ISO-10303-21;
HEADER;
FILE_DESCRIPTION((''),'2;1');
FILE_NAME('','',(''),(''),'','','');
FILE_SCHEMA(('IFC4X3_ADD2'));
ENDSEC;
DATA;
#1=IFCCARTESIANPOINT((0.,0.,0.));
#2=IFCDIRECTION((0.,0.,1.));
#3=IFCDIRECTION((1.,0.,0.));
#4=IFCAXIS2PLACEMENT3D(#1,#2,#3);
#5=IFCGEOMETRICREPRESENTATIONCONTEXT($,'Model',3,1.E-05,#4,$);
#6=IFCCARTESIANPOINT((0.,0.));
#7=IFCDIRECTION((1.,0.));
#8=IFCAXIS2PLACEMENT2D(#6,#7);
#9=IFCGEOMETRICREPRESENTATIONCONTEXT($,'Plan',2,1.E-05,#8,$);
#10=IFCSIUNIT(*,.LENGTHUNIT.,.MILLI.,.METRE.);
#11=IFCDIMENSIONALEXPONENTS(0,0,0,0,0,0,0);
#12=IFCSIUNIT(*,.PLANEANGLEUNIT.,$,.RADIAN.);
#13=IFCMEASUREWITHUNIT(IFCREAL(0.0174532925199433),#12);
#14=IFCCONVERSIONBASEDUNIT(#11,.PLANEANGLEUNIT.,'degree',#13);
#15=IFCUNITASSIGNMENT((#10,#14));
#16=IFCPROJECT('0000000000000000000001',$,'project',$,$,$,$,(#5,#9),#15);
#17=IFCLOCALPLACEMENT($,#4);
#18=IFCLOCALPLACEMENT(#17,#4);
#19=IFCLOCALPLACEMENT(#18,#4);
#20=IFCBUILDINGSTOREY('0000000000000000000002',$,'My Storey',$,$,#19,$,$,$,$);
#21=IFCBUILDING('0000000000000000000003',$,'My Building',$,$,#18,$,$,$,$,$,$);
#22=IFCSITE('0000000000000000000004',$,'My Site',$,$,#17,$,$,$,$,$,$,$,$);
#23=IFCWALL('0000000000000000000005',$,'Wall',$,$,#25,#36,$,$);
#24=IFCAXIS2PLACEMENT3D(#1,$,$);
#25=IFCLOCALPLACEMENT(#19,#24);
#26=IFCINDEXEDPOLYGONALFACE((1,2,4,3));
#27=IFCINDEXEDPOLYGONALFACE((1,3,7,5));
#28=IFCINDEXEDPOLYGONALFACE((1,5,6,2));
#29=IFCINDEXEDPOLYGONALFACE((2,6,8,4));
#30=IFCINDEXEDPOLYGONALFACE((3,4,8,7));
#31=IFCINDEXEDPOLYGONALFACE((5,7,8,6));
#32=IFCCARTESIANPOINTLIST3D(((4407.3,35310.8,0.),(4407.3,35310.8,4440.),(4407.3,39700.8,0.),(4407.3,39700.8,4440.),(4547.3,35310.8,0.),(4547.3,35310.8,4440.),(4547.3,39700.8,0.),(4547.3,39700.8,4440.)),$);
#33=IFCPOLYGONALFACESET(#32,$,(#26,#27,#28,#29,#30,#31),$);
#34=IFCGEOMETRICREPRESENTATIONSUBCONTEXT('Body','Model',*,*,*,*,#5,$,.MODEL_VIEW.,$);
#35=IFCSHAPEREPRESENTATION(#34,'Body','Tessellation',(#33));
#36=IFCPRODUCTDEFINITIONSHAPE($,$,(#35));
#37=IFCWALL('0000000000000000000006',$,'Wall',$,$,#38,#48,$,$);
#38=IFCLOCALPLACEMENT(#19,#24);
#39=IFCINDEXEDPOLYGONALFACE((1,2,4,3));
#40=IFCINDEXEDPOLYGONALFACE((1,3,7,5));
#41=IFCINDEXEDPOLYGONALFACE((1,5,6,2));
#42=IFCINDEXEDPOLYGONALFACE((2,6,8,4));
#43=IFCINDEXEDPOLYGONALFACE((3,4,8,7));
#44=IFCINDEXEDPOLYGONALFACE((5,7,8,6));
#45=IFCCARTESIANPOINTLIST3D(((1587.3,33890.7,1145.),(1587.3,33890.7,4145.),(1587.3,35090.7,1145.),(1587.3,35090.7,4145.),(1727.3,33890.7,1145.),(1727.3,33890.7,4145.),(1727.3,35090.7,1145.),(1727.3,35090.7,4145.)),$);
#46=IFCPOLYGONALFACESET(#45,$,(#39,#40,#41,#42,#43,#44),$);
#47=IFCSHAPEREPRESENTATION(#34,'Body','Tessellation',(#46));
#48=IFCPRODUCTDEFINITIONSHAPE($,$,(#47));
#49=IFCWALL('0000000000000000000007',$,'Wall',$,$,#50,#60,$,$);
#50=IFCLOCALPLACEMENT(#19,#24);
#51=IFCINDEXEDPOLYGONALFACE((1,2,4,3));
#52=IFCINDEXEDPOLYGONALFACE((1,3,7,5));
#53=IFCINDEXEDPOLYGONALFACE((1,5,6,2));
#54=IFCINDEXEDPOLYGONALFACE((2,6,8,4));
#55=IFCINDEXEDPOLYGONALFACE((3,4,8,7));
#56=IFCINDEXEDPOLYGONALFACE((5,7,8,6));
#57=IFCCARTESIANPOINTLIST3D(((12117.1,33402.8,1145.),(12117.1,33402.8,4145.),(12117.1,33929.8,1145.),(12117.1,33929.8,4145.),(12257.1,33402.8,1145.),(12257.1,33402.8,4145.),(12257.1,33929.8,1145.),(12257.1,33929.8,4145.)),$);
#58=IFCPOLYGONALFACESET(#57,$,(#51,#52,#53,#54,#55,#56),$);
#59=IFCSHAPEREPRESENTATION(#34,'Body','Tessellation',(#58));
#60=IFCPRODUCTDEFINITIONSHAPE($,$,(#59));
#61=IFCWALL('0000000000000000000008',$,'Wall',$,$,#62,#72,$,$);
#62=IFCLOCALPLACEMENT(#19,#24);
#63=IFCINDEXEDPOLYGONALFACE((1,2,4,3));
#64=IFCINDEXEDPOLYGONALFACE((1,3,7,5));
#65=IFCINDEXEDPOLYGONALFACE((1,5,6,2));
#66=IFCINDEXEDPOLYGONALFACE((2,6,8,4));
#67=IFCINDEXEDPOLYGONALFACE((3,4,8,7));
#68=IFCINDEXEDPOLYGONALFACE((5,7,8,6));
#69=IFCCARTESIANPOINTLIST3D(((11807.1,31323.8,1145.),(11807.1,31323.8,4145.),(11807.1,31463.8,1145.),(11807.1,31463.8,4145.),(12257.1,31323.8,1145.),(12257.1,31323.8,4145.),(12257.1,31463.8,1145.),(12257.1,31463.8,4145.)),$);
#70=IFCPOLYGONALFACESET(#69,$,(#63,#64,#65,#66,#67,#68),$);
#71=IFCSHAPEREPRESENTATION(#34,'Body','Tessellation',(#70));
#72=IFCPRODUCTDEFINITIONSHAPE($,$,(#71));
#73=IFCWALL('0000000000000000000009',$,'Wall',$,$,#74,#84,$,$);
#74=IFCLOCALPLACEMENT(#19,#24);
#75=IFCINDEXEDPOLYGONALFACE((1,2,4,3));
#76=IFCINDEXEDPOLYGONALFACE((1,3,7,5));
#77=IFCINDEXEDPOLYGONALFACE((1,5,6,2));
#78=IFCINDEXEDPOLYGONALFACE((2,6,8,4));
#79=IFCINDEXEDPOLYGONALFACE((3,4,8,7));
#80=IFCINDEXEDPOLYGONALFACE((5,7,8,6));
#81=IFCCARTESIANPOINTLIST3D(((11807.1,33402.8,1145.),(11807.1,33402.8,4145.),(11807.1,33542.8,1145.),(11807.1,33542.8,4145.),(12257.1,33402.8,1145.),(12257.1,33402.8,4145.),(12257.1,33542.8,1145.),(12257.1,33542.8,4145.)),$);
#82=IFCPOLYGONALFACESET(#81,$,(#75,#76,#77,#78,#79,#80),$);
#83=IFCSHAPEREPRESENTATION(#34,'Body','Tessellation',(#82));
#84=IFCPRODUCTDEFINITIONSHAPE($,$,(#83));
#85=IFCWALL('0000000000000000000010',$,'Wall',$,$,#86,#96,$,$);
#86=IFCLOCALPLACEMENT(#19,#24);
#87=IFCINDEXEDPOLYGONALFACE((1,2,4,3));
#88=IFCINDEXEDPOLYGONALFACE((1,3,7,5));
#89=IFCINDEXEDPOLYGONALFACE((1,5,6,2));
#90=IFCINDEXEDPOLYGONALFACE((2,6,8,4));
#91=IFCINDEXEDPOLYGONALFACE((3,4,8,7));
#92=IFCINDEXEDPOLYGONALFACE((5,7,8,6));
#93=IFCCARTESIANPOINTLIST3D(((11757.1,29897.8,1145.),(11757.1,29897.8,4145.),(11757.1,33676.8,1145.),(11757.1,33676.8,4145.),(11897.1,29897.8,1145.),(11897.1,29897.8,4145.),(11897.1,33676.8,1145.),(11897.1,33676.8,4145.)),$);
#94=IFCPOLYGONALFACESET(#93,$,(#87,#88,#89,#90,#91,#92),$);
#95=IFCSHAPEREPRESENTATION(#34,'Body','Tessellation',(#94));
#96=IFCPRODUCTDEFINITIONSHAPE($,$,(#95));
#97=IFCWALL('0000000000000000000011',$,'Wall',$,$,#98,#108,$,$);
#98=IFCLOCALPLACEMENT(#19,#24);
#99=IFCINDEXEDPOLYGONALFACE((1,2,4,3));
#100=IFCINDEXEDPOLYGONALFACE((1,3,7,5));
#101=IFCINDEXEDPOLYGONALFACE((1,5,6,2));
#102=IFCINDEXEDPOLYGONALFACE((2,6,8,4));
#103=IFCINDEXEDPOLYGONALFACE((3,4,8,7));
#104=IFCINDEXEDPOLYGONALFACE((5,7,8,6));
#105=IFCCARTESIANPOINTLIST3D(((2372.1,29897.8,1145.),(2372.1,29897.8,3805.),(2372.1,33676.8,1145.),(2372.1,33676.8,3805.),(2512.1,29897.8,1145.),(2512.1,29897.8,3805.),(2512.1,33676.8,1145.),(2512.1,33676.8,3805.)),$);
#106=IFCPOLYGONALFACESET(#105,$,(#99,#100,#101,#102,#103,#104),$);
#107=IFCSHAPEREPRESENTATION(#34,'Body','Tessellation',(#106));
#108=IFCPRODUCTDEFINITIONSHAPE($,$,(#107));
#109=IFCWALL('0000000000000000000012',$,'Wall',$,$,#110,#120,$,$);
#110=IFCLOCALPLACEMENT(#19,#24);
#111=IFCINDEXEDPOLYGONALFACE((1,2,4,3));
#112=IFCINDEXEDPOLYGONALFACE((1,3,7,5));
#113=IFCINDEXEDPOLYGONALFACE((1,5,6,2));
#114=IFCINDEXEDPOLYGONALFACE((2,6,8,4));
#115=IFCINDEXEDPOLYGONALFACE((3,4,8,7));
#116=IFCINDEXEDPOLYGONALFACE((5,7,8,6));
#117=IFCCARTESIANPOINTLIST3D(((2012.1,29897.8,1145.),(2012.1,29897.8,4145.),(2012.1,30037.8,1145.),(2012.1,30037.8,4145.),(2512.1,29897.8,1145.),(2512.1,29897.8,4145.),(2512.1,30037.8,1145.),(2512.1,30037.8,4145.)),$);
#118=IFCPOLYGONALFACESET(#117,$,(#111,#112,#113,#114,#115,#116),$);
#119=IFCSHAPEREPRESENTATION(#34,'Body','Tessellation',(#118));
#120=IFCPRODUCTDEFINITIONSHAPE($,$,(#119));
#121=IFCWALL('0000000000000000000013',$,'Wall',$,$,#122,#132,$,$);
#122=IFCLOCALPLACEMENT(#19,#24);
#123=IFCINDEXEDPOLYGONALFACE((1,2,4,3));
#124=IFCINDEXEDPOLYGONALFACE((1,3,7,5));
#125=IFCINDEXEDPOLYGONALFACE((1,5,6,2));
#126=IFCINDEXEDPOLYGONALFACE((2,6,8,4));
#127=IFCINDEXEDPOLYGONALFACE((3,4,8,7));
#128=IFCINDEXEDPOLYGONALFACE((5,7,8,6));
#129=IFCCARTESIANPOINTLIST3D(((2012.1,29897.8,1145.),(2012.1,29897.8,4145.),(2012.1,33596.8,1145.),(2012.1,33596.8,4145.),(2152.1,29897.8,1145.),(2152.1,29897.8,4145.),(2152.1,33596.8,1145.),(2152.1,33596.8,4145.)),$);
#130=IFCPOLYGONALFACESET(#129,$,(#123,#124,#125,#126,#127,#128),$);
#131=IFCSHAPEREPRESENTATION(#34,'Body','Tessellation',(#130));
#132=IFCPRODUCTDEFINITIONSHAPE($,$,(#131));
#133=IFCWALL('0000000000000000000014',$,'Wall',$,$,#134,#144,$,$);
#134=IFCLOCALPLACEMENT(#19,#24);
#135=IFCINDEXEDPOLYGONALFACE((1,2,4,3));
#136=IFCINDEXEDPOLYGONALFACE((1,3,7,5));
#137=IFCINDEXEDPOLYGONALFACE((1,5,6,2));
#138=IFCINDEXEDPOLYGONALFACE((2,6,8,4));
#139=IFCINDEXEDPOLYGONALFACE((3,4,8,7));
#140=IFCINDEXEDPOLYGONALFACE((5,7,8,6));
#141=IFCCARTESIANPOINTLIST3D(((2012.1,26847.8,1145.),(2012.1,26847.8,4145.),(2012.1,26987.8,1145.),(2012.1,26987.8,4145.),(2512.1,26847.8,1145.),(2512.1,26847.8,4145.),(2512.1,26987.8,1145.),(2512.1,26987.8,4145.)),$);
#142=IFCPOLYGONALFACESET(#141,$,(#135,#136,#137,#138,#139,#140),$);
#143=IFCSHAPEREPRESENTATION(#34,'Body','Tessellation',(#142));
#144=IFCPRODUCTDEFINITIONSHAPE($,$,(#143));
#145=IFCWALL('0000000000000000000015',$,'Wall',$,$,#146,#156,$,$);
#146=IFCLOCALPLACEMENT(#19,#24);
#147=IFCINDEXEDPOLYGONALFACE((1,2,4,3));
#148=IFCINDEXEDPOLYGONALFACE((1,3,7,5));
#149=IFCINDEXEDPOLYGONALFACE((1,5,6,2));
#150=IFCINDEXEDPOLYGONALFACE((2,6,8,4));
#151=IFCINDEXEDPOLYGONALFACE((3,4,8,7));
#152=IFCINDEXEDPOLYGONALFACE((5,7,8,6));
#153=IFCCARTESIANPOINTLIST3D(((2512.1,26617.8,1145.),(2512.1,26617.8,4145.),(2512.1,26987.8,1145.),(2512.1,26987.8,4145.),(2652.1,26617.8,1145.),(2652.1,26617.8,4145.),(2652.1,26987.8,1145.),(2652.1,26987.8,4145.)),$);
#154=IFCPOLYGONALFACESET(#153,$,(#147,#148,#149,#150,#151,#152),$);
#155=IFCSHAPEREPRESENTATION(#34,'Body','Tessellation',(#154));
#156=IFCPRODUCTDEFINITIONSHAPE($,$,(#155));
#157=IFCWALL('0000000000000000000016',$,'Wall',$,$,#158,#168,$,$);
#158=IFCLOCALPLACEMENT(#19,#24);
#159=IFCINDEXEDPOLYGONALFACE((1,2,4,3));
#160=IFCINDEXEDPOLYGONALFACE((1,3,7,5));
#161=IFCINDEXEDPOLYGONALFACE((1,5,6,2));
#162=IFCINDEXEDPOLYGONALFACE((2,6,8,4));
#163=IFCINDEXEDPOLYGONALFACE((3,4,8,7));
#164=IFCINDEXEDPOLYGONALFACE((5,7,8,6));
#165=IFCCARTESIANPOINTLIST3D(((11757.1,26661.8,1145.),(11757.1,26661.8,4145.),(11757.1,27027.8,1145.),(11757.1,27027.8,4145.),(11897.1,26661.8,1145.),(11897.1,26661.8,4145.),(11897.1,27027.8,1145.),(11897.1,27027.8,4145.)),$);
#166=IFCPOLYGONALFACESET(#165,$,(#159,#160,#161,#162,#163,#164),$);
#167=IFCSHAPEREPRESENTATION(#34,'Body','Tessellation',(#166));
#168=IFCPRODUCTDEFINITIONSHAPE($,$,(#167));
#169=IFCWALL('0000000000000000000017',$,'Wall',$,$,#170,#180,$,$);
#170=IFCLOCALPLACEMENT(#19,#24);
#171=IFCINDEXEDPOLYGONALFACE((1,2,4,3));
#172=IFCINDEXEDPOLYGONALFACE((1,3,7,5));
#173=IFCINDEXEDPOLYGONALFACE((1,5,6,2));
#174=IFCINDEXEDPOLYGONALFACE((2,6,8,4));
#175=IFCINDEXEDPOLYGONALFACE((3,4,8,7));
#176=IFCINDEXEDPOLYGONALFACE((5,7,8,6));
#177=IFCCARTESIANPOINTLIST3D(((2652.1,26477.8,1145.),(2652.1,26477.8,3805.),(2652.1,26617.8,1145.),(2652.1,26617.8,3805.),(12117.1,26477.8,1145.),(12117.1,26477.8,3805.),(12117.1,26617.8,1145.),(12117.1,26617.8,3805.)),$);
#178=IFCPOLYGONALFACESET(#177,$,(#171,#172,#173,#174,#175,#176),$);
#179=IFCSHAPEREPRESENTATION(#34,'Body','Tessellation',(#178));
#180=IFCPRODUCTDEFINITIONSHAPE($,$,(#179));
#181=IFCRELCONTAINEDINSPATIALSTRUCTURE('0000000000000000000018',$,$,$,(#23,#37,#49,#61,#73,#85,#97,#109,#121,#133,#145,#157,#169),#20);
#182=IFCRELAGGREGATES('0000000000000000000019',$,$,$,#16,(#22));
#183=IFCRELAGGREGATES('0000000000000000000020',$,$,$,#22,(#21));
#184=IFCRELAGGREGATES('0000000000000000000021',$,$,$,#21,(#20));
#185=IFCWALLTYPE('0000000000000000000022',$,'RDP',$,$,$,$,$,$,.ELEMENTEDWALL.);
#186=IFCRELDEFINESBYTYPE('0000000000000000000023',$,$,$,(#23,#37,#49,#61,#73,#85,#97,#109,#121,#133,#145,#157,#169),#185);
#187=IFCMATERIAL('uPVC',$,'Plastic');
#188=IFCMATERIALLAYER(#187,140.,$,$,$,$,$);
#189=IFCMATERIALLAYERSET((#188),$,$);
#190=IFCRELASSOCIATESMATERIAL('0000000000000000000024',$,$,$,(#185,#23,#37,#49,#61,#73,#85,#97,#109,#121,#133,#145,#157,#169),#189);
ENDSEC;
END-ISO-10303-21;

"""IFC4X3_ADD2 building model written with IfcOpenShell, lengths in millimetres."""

from ifc_helpers import new_model, entity, si_unit, converted_unit, frame, origin_with_axes, origin_2d_with_axis, place, context, subcontext, project, spatial, line, indexed_curve, outline, extrude, material, layer, layer_set, layer_usage, type_object, element, save


model = new_model("IFC4X3_ADD2")

# Units and contexts
model_context = context("Model", 3, precision=1e-05, world=origin_with_axes())
plan_context = context("Plan", 2, precision=1e-05, world=origin_2d_with_axis())
body_context_1 = subcontext(model_context, "Body", "Model", "MODEL_VIEW")
ifc_project = project(units=[si_unit("LENGTHUNIT", "METRE", prefix="MILLI"), converted_unit("PLANEANGLEUNIT", "degree", entity("IfcReal", 0.0174532925199433), si_unit("PLANEANGLEUNIT", "RADIAN"), dimensions=[0, 0, 0, 0, 0, 0, 0])], contexts=[model_context, plan_context])

# Site, building, storey
site_placement = place(None, origin_with_axes())
site = spatial("IfcSite", under=ifc_project, at=site_placement, Name="My Site")
building_placement = place(site_placement, origin_with_axes())
building = spatial("IfcBuilding", under=site, at=building_placement, Name="My Building")
storey_placement = place(building_placement, origin_with_axes())
storey = spatial("IfcBuildingStorey", under=building, at=storey_placement, Name="My Storey")

# Shared definitions
ifc_material_1 = material(Name="uPVC", Category="Plastic")
ifc_layer_1 = layer(ifc_material_1, 140.0)
ifc_layer_set_1 = layer_set([ifc_layer_1])
wall_type_1 = type_object("IfcWallType", Name="RDP", PredefinedType="ELEMENTEDWALL", material=ifc_layer_set_1)

# Walls
ifc_layer_usage_1 = layer_usage(ifc_layer_set_1, "AXIS2", "POSITIVE", 0.0)
wall_1_placement = place(storey_placement, frame((4407.3, 39700.8, 0.0), z_axis=(0.0, 0.0, 1.0), x_axis=(0.000003, -1.0, 0.0)))
element("IfcWall", 1, at=wall_1_placement, inside=storey, type_object=wall_type_1, material=ifc_layer_usage_1, Name="Wall", context=body_context_1, shape_type="SweptSolid", body=[
    extrude(outline(indexed_curve([(0.0, 0.0), (0.0, 140.0), (4390.0, 140.0), (4390.0, 0.0)], segments=[line(1, 2, 3, 4, 1)])), origin_with_axes(), (0.0, 0.0, 1.0), 4440.0),
])
ifc_layer_usage_2 = layer_usage(ifc_layer_set_1, "AXIS2", "POSITIVE", 0.0)
wall_2_placement = place(storey_placement, frame((1727.3, 33890.7, 1145.0), z_axis=(0.0, 0.0, 1.0), x_axis=(-0.000003, 1.0, 0.0)))
element("IfcWall", 2, at=wall_2_placement, inside=storey, type_object=wall_type_1, material=ifc_layer_usage_2, Name="Wall", context=body_context_1, shape_type="SweptSolid", body=[
    extrude(outline(indexed_curve([(0.0, 0.0), (0.0, 140.0), (1200.0, 140.0), (1200.0, 0.0)], segments=[line(1, 2, 3, 4, 1)])), origin_with_axes(), (0.0, 0.0, 1.0), 3000.0),
])

# Walls
ifc_layer_usage_3 = layer_usage(ifc_layer_set_1, "AXIS2", "POSITIVE", 0.0)
wall_3_placement = place(storey_placement, frame((12117.1, 33929.8, 1145.0), z_axis=(0.0, 0.0, 1.0), x_axis=(0.000004, -1.0, 0.0)))
element("IfcWall", 3, at=wall_3_placement, inside=storey, type_object=wall_type_1, material=ifc_layer_usage_3, Name="Wall", context=body_context_1, shape_type="SweptSolid", body=[
    extrude(outline(indexed_curve([(0.0, 0.0), (0.0, 140.0), (527.0, 140.0), (527.0, 0.0)], segments=[line(1, 2, 3, 4, 1)])), origin_with_axes(), (0.0, 0.0, 1.0), 3000.0),
])
ifc_layer_usage_4 = layer_usage(ifc_layer_set_1, "AXIS2", "POSITIVE", 0.0)
wall_4_placement = place(storey_placement, frame((11807.1, 31323.8, 1145.0), z_axis=(0.0, 0.0, 1.0), x_axis=(1.0, 0.000004, 0.0)))
element("IfcWall", 4, at=wall_4_placement, inside=storey, type_object=wall_type_1, material=ifc_layer_usage_4, Name="Wall", context=body_context_1, shape_type="SweptSolid", body=[
    extrude(outline(indexed_curve([(0.0, 0.0), (0.0, 140.0), (450.0, 140.0), (450.0, 0.0)], segments=[line(1, 2, 3, 4, 1)])), origin_with_axes(), (0.0, 0.0, 1.0), 3000.0),
])
ifc_layer_usage_5 = layer_usage(ifc_layer_set_1, "AXIS2", "POSITIVE", 0.0)
wall_5_placement = place(storey_placement, frame((11807.1, 33402.8, 1145.0), z_axis=(0.0, 0.0, 1.0), x_axis=(1.0, 0.000004, 0.0)))
element("IfcWall", 5, at=wall_5_placement, inside=storey, type_object=wall_type_1, material=ifc_layer_usage_5, Name="Wall", context=body_context_1, shape_type="SweptSolid", body=[
    extrude(outline(indexed_curve([(0.0, 0.0), (0.0, 140.0), (450.0, 140.0), (450.0, 0.0)], segments=[line(1, 2, 3, 4, 1)])), origin_with_axes(), (0.0, 0.0, 1.0), 3000.0),
])
ifc_layer_usage_6 = layer_usage(ifc_layer_set_1, "AXIS2", "POSITIVE", 0.0)
wall_6_placement = place(storey_placement, frame((11897.1, 29897.8, 1145.0), z_axis=(0.0, 0.0, 1.0), x_axis=(-0.000004, 1.0, 0.0)))
element("IfcWall", 6, at=wall_6_placement, inside=storey, type_object=wall_type_1, material=ifc_layer_usage_6, Name="Wall", context=body_context_1, shape_type="SweptSolid", body=[
    extrude(outline(indexed_curve([(0.0, 0.0), (0.0, 140.0), (3779.0, 140.0), (3779.0, 0.0)], segments=[line(1, 2, 3, 4, 1)])), origin_with_axes(), (0.0, 0.0, 1.0), 3000.0),
])
ifc_layer_usage_7 = layer_usage(ifc_layer_set_1, "AXIS2", "POSITIVE", 0.0)
wall_7_placement = place(storey_placement, frame((2512.1, 29897.8, 1145.0), z_axis=(0.0, 0.0, 1.0), x_axis=(-0.000004, 1.0, 0.0)))
element("IfcWall", 7, at=wall_7_placement, inside=storey, type_object=wall_type_1, material=ifc_layer_usage_7, Name="Wall", context=body_context_1, shape_type="SweptSolid", body=[
    extrude(outline(indexed_curve([(0.0, 0.0), (0.0, 140.0), (3779.0, 140.0), (3779.0, 0.0)], segments=[line(1, 2, 3, 4, 1)])), origin_with_axes(), (0.0, 0.0, 1.0), 2660.0),
])
ifc_layer_usage_8 = layer_usage(ifc_layer_set_1, "AXIS2", "POSITIVE", 0.0)
wall_8_placement = place(storey_placement, frame((2512.1, 30037.8, 1145.0), z_axis=(0.0, 0.0, 1.0), x_axis=(-1.0, -0.000004, 0.0)))
element("IfcWall", 8, at=wall_8_placement, inside=storey, type_object=wall_type_1, material=ifc_layer_usage_8, Name="Wall", context=body_context_1, shape_type="SweptSolid", body=[
    extrude(outline(indexed_curve([(0.0, 0.0), (0.0, 140.0), (500.0, 140.0), (500.0, 0.0)], segments=[line(1, 2, 3, 4, 1)])), origin_with_axes(), (0.0, 0.0, 1.0), 3000.0),
])
ifc_layer_usage_9 = layer_usage(ifc_layer_set_1, "AXIS2", "POSITIVE", 0.0)
wall_9_placement = place(storey_placement, frame((2012.1, 33596.8, 1145.0), z_axis=(0.0, 0.0, 1.0), x_axis=(0.000004, -1.0, 0.0)))
element("IfcWall", 9, at=wall_9_placement, inside=storey, type_object=wall_type_1, material=ifc_layer_usage_9, Name="Wall", context=body_context_1, shape_type="SweptSolid", body=[
    extrude(outline(indexed_curve([(0.0, 0.0), (0.0, 140.0), (3699.0, 140.0), (3699.0, 0.0)], segments=[line(1, 2, 3, 4, 1)])), origin_with_axes(), (0.0, 0.0, 1.0), 3000.0),
])
ifc_layer_usage_10 = layer_usage(ifc_layer_set_1, "AXIS2", "POSITIVE", 0.0)
wall_10_placement = place(storey_placement, frame((2512.1, 26987.8, 1145.0), z_axis=(0.0, 0.0, 1.0), x_axis=(-1.0, -0.000004, 0.0)))
element("IfcWall", 10, at=wall_10_placement, inside=storey, type_object=wall_type_1, material=ifc_layer_usage_10, Name="Wall", context=body_context_1, shape_type="SweptSolid", body=[
    extrude(outline(indexed_curve([(0.0, 0.0), (0.0, 140.0), (500.0, 140.0), (500.0, 0.0)], segments=[line(1, 2, 3, 4, 1)])), origin_with_axes(), (0.0, 0.0, 1.0), 3000.0),
])
ifc_layer_usage_11 = layer_usage(ifc_layer_set_1, "AXIS2", "POSITIVE", 0.0)
wall_11_placement = place(storey_placement, frame((2512.1, 26987.8, 1145.0), z_axis=(0.0, 0.0, 1.0), x_axis=(0.000004, -1.0, 0.0)))
element("IfcWall", 11, at=wall_11_placement, inside=storey, type_object=wall_type_1, material=ifc_layer_usage_11, Name="Wall", context=body_context_1, shape_type="SweptSolid", body=[
    extrude(outline(indexed_curve([(0.0, 0.0), (0.0, 140.0), (370.0, 140.0), (370.0, 0.0)], segments=[line(1, 2, 3, 4, 1)])), origin_with_axes(), (0.0, 0.0, 1.0), 3000.0),
])
ifc_layer_usage_12 = layer_usage(ifc_layer_set_1, "AXIS2", "POSITIVE", 0.0)
wall_12_placement = place(storey_placement, frame((11757.1, 27027.8, 1145.0), z_axis=(0.0, 0.0, 1.0), x_axis=(0.000004, -1.0, 0.0)))
element("IfcWall", 12, at=wall_12_placement, inside=storey, type_object=wall_type_1, material=ifc_layer_usage_12, Name="Wall", context=body_context_1, shape_type="SweptSolid", body=[
    extrude(outline(indexed_curve([(0.0, 0.0), (0.0, 140.0), (366.0, 140.0), (366.0, 0.0)], segments=[line(1, 2, 3, 4, 1)])), origin_with_axes(), (0.0, 0.0, 1.0), 3000.0),
])
ifc_layer_usage_13 = layer_usage(ifc_layer_set_1, "AXIS2", "POSITIVE", 0.0)
wall_13_placement = place(storey_placement, frame((2652.1, 26477.8, 1145.0), z_axis=(0.0, 0.0, 1.0), x_axis=(1.0, 0.000004, 0.0)))
element("IfcWall", 13, at=wall_13_placement, inside=storey, type_object=wall_type_1, material=ifc_layer_usage_13, Name="Wall", context=body_context_1, shape_type="SweptSolid", body=[
    extrude(outline(indexed_curve([(0.0, 0.0), (0.0, 140.0), (9465.0, 140.0), (9465.0, 0.0)], segments=[line(1, 2, 3, 4, 1)])), origin_with_axes(), (0.0, 0.0, 1.0), 2660.0),
])

save(model, "model.ifc")
